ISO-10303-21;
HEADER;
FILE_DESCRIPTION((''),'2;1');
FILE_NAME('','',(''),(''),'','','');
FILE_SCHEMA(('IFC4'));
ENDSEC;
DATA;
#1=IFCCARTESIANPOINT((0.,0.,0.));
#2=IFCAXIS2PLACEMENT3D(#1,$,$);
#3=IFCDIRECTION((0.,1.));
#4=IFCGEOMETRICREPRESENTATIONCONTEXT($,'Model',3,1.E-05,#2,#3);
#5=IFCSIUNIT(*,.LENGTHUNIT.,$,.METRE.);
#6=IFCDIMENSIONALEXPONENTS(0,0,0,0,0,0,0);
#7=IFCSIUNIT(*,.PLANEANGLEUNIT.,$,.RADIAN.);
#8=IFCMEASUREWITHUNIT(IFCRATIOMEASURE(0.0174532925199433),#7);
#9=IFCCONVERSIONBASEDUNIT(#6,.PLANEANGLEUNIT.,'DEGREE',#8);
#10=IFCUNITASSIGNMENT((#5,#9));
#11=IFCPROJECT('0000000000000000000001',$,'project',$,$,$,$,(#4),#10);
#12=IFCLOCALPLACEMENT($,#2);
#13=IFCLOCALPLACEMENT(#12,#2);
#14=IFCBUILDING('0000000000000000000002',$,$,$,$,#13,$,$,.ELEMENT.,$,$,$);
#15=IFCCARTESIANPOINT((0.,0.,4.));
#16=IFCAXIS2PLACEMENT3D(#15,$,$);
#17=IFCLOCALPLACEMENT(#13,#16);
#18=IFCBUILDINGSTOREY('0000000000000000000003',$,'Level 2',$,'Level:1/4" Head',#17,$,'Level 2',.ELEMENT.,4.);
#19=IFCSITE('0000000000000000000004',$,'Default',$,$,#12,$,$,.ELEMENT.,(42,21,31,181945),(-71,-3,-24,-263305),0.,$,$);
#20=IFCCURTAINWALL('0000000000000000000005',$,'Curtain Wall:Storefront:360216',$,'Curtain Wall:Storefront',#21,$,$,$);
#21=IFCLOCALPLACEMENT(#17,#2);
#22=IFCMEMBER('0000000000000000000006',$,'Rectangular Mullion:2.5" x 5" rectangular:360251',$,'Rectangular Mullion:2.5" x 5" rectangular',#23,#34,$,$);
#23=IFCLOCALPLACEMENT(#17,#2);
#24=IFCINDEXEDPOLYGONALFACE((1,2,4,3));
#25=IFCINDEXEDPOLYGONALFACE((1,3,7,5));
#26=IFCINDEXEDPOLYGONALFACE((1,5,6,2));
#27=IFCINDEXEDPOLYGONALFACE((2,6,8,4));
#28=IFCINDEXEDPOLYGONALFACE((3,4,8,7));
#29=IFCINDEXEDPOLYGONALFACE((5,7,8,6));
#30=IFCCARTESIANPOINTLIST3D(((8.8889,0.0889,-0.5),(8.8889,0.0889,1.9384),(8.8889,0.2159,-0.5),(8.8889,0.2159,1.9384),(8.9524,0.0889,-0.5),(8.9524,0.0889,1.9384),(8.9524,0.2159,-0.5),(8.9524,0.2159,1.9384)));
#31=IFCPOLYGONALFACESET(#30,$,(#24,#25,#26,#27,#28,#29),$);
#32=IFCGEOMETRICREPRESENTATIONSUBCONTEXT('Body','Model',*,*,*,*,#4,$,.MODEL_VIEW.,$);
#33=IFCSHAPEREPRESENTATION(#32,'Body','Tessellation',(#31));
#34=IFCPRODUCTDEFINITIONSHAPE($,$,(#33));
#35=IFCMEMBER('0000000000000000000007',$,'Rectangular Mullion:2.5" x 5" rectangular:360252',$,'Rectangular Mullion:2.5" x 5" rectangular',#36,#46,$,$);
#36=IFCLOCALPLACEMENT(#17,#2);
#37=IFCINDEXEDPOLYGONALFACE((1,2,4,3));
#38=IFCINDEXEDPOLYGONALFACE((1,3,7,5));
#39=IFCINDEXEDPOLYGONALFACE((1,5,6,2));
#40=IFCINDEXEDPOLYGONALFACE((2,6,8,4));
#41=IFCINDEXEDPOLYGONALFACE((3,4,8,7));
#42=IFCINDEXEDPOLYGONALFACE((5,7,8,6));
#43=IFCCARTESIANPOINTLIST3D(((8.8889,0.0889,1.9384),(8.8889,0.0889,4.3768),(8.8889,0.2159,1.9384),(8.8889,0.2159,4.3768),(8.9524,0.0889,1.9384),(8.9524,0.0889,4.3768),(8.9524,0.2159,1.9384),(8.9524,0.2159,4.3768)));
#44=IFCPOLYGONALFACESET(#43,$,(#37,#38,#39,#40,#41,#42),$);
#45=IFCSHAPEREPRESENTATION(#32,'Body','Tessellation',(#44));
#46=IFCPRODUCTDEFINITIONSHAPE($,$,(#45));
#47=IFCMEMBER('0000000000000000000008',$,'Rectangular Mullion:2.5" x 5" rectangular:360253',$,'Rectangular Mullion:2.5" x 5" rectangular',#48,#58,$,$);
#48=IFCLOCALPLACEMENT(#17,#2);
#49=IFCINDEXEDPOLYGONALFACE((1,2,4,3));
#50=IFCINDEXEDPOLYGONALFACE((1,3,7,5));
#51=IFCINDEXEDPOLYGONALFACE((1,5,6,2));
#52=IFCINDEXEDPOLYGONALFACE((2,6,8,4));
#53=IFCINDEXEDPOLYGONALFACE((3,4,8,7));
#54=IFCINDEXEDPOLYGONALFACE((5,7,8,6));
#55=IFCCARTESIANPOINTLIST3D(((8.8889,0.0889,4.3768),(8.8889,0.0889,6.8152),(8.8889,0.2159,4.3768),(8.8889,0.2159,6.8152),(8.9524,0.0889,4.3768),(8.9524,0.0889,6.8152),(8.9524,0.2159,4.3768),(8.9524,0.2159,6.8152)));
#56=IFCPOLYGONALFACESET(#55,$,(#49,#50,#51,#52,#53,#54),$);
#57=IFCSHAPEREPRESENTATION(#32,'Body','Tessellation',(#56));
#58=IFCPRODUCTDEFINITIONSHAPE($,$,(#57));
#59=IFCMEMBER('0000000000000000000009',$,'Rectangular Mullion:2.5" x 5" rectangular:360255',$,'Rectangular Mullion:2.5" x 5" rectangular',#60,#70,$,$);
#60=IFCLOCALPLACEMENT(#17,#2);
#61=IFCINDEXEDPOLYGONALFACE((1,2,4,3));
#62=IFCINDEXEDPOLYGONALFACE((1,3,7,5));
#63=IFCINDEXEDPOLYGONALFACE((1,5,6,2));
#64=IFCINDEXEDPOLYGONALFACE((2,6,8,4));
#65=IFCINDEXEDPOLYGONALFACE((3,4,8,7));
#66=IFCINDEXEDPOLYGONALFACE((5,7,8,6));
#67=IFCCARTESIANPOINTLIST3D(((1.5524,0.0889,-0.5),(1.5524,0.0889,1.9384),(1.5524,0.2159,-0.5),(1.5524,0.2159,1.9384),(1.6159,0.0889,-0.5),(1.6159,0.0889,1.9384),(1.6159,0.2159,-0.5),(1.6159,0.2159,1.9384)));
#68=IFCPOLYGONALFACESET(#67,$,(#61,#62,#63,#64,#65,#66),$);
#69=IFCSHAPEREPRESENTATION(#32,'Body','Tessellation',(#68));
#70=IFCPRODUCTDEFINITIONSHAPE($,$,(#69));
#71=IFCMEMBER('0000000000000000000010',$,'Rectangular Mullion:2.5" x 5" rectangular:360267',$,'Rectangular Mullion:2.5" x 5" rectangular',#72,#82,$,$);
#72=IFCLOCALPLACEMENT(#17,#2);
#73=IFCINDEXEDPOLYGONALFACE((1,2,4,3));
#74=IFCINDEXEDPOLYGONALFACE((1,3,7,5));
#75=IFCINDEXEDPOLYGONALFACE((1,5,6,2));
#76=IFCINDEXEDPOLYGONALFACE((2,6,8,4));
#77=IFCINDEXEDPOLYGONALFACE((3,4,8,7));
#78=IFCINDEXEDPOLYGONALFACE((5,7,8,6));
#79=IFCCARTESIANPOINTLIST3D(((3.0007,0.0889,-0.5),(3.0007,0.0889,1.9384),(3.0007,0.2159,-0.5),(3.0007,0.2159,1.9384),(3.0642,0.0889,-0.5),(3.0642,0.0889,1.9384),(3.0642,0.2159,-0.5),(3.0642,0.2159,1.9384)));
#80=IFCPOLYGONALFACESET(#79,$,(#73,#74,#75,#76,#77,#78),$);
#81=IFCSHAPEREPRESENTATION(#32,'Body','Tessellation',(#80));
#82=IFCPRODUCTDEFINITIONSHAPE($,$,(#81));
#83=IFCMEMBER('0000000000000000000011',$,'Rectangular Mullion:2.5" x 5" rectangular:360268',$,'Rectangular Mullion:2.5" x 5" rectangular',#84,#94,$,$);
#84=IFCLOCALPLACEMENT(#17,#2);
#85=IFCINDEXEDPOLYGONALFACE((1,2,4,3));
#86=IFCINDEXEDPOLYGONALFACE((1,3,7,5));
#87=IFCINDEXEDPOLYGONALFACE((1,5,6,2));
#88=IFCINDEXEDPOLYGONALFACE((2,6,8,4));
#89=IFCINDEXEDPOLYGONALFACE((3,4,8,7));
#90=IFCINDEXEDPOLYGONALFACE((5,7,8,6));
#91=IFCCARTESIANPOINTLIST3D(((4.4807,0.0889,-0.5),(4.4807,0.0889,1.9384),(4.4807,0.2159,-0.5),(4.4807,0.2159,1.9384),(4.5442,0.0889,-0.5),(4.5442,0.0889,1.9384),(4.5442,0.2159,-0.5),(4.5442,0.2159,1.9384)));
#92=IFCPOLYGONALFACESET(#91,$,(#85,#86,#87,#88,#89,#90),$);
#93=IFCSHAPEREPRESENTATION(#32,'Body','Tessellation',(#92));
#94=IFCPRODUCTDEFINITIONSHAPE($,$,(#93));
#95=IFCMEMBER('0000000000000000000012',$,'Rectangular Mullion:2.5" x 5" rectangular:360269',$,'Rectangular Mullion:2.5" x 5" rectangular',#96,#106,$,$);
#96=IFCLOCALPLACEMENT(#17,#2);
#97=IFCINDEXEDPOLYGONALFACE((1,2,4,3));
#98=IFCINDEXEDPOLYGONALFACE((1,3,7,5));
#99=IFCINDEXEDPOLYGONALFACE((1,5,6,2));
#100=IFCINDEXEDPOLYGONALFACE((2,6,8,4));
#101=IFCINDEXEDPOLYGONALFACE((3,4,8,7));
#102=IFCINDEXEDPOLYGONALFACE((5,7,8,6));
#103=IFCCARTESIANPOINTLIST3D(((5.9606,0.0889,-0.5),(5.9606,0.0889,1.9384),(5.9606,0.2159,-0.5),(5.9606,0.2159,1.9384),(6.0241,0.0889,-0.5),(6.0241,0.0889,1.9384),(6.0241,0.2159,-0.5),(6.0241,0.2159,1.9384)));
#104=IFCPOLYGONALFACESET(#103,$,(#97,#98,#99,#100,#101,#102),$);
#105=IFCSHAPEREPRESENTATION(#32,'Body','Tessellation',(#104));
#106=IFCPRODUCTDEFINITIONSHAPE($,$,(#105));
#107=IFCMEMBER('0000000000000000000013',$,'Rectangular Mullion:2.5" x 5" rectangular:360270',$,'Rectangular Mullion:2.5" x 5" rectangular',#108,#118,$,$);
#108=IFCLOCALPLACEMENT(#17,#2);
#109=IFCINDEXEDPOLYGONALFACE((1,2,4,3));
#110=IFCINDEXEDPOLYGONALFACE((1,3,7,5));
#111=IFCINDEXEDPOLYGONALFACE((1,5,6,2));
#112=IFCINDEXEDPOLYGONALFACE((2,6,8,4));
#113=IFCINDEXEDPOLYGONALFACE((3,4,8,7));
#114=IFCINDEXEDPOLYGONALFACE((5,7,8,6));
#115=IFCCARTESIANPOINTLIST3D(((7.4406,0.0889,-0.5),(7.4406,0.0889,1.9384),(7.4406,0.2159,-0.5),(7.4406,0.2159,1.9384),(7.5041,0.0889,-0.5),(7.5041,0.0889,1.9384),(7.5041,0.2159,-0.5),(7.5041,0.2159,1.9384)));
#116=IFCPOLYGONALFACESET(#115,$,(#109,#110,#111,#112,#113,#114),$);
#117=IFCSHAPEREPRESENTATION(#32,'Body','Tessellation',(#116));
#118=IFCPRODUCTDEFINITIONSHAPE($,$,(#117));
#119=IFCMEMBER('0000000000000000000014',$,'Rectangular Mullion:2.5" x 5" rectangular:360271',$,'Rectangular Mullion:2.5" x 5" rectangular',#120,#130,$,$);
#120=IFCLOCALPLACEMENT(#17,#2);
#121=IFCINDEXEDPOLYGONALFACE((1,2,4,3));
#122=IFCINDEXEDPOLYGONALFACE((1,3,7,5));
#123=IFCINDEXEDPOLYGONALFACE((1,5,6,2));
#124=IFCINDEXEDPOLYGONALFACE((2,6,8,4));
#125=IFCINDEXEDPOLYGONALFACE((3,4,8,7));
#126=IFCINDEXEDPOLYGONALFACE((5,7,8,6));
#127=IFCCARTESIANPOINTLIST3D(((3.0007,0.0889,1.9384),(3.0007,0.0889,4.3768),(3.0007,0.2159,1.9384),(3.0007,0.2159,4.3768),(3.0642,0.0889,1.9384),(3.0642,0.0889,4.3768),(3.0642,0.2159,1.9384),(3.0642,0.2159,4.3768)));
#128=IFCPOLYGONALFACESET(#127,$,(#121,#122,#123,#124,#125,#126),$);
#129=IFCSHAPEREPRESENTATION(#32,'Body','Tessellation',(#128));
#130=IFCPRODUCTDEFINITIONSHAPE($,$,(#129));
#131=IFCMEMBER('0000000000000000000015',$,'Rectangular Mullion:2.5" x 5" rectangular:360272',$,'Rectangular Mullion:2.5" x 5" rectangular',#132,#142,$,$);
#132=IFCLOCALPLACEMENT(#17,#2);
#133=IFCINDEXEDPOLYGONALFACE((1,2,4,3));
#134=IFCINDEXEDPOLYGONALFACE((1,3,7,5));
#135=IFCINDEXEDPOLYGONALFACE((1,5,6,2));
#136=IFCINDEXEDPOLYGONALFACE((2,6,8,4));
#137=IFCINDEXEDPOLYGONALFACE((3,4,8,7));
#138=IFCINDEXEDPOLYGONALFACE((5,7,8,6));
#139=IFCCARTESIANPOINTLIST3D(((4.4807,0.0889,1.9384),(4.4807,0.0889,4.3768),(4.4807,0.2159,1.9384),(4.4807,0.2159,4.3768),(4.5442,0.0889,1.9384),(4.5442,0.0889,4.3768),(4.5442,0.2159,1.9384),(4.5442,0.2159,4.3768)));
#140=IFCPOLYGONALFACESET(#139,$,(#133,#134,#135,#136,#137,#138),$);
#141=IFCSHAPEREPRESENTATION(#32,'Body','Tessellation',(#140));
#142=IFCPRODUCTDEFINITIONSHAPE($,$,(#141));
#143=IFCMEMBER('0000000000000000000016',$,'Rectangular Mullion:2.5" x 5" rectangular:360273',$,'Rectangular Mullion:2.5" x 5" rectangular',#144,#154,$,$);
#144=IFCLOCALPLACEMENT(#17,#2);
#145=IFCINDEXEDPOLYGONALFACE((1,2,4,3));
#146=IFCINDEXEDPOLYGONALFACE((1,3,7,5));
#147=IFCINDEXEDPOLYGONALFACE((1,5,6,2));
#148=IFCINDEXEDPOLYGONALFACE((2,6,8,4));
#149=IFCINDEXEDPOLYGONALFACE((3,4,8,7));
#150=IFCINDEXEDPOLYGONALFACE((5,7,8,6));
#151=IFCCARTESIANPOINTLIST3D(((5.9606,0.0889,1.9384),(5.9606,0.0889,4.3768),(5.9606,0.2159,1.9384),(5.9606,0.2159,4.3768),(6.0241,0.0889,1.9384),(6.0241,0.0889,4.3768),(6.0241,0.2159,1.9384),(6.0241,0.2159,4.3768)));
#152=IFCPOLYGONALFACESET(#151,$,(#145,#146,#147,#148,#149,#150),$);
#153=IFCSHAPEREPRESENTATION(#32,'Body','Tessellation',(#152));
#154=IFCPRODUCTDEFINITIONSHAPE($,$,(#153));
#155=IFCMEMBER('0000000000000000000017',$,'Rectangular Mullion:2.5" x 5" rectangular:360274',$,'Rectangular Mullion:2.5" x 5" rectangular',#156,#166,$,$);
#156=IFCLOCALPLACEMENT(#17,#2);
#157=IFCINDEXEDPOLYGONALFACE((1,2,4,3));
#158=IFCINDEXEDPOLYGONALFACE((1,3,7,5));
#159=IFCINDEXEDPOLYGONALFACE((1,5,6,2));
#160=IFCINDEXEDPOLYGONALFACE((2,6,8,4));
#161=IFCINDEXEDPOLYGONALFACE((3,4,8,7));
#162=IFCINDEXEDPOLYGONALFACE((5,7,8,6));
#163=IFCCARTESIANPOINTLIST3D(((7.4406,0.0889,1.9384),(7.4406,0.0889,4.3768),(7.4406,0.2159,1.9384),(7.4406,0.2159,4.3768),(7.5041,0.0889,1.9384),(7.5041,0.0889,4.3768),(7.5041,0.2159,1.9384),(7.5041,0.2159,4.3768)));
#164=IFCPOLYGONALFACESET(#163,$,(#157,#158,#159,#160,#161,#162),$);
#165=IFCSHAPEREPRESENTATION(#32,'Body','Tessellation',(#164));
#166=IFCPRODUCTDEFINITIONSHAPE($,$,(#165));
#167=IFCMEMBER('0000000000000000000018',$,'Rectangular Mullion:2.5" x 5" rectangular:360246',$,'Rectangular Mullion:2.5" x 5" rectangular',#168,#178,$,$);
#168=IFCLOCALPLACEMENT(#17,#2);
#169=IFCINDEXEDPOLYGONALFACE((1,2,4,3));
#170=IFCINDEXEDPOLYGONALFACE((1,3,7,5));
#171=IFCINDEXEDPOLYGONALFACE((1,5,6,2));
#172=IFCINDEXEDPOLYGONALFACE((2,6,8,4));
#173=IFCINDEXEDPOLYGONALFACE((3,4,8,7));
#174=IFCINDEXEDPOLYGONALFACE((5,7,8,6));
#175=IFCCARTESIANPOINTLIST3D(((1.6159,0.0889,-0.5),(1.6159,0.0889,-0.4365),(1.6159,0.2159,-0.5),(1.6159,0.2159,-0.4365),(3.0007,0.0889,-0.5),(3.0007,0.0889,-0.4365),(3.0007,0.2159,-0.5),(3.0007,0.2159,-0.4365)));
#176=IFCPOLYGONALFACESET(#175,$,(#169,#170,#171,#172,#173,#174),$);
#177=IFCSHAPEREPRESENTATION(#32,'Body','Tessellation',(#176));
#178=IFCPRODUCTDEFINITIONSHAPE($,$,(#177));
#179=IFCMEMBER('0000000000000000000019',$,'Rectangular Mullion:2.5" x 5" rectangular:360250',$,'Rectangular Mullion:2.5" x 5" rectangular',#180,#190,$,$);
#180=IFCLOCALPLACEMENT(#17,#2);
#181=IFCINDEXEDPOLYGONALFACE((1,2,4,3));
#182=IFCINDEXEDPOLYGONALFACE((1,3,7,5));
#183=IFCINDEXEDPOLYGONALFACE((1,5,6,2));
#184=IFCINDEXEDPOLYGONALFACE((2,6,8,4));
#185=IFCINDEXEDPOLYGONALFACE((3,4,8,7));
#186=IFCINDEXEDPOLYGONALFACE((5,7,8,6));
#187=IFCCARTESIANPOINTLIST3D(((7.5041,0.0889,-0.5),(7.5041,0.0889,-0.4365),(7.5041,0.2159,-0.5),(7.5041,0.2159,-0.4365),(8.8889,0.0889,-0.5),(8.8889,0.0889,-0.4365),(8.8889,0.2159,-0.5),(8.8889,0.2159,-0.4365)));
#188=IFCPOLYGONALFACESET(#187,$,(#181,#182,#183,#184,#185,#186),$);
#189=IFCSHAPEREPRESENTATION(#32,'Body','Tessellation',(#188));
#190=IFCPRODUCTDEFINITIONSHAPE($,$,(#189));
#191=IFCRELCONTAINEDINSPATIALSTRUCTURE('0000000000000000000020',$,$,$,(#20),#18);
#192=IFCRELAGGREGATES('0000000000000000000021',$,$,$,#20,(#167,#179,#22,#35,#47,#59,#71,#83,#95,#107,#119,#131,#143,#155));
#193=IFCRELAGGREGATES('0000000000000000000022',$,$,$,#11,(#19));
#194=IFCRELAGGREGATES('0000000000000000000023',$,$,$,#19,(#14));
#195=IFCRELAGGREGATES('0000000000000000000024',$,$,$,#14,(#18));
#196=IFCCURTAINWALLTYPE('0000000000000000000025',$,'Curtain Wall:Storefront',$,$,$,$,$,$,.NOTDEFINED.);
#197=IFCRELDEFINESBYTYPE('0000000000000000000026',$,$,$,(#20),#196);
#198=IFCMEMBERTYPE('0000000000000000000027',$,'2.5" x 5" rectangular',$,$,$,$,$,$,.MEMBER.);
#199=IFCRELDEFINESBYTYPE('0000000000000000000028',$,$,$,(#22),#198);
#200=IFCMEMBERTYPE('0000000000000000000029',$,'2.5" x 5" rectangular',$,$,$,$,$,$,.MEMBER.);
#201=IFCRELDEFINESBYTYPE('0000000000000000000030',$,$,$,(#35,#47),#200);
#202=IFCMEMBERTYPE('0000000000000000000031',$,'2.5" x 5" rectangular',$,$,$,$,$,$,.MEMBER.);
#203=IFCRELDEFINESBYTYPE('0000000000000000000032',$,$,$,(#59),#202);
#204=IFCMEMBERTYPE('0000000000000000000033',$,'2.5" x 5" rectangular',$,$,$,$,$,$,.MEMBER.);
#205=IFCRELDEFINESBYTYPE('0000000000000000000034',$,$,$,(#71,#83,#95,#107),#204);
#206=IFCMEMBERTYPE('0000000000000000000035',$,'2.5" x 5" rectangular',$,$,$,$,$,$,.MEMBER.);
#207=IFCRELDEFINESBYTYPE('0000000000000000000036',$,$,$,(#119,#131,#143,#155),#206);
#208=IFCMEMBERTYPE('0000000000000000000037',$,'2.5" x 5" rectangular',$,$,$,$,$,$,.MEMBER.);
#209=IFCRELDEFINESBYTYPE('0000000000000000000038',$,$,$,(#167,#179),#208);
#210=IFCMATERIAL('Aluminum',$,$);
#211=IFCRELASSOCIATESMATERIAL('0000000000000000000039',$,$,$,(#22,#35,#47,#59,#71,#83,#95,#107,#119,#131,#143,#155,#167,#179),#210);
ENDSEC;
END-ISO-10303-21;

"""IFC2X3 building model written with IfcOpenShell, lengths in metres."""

from ifc_helpers import new_model, entity, si_unit, converted_unit, direction, frame, origin, origin_2d_with_axis, place, context, subcontext, project, spatial, rectangle, extrude, source, transform, mapped, material, type_object, type_shapes, element, aggregate, save


model = new_model("IFC2X3")

# Units and contexts
model_context = context("Model", 3, precision=1e-05, world=origin(), true_north=direction((0.0, 1.0)))
body_context = subcontext(model_context, "Body", "Model", "MODEL_VIEW")
ifc_project = project(units=[si_unit("LENGTHUNIT", "METRE"), converted_unit("PLANEANGLEUNIT", "DEGREE", entity("IfcRatioMeasure", 0.0174532925199433), si_unit("PLANEANGLEUNIT", "RADIAN"), dimensions=[0, 0, 0, 0, 0, 0, 0])], contexts=[model_context])

# Site, building, storey
site_placement = place(None, origin())
site = spatial("IfcSite", under=ifc_project, at=site_placement, Name="Default", CompositionType="ELEMENT", RefLatitude=(42, 21, 31, 181945), RefLongitude=(-71, -3, -24, -263305), RefElevation=0.0)
building_placement = place(site_placement, origin())
building = spatial("IfcBuilding", under=site, at=building_placement, CompositionType="ELEMENT")
storey_placement = place(building_placement, frame((0.0, 0.0, 4.0)))
storey = spatial("IfcBuildingStorey", under=building, at=storey_placement, Name="Level 2", ObjectType="Level:1/4\" Head", LongName="Level 2", CompositionType="ELEMENT", Elevation=4.0)

# Curtain wall, members
curtain_wall_type = type_object("IfcCurtainWallType", Name="Curtain Wall:Storefront", PredefinedType="NOTDEFINED")
curtain_wall_placement = place(storey_placement, frame((0.0, 0.0, -4.0)))
curtain_wall = element("IfcCurtainWall", 1, at=curtain_wall_placement, inside=storey, type_object=curtain_wall_type, Name="Curtain Wall:Storefront:360216", ObjectType="Curtain Wall:Storefront")
ifc_material_1 = material(Name="Aluminum")
member_type_1 = type_object("IfcMemberType", Name="2.5\" x 5\" rectangular", PredefinedType="MEMBER")
shared_shape_1 = source(origin(), body_context, "Body", "SweptSolid", [
    extrude(rectangle(XDim=0.127, YDim=0.0635, at=origin_2d_with_axis()), frame((-0.0318, 0.0, -2.4384), z_axis=(0.0, 0.0, 1.0), x_axis=(0.0, -1.0, 0.0)), (0.0, 0.0, 1.0), 2.4384),
])
type_shapes(member_type_1, [shared_shape_1])
member_1_placement = place(storey_placement, frame((8.9524, 0.1524, -0.5), z_axis=(0.0, 0.0, -1.0), x_axis=(1.0, 0.0, 0.0)))
member_1 = element("IfcMember", 2, at=member_1_placement, type_object=member_type_1, material=ifc_material_1, Name="Rectangular Mullion:2.5\" x 5\" rectangular:360251", ObjectType="Rectangular Mullion:2.5\" x 5\" rectangular", context=body_context, shape_type="MappedRepresentation", body=[
    mapped(shared_shape_1, transform((0.0, 0.0, 0.0), scale=1.0)),
])
member_type_2 = type_object("IfcMemberType", Name="2.5\" x 5\" rectangular", PredefinedType="MEMBER")
shared_shape_2 = source(origin(), body_context, "Body", "SweptSolid", [
    extrude(rectangle(XDim=0.127, YDim=0.0635, at=origin_2d_with_axis()), frame((-0.0318, 0.0, -2.4384), z_axis=(0.0, 0.0, 1.0), x_axis=(0.0, -1.0, 0.0)), (0.0, 0.0, 1.0), 2.4384),
])
type_shapes(member_type_2, [shared_shape_2])
member_2_placement = place(storey_placement, frame((8.9524, 0.1524, 1.9384), z_axis=(0.0, 0.0, -1.0), x_axis=(1.0, 0.0, 0.0)))
member_2 = element("IfcMember", 3, at=member_2_placement, type_object=member_type_2, material=ifc_material_1, Name="Rectangular Mullion:2.5\" x 5\" rectangular:360252", ObjectType="Rectangular Mullion:2.5\" x 5\" rectangular", context=body_context, shape_type="MappedRepresentation", body=[
    mapped(shared_shape_2, transform((0.0, 0.0, 0.0), scale=1.0)),
])
member_3_placement = place(storey_placement, frame((8.9524, 0.1524, 4.3768), z_axis=(0.0, 0.0, -1.0), x_axis=(1.0, 0.0, 0.0)))
member_3 = element("IfcMember", 4, at=member_3_placement, type_object=member_type_2, material=ifc_material_1, Name="Rectangular Mullion:2.5\" x 5\" rectangular:360253", ObjectType="Rectangular Mullion:2.5\" x 5\" rectangular", context=body_context, shape_type="MappedRepresentation", body=[
    mapped(shared_shape_2, transform((0.0, 0.0, 0.0), scale=1.0)),
])
member_type_3 = type_object("IfcMemberType", Name="2.5\" x 5\" rectangular", PredefinedType="MEMBER")
shared_shape_3 = source(origin(), body_context, "Body", "SweptSolid", [
    extrude(rectangle(XDim=0.127, YDim=0.0635, at=origin_2d_with_axis()), frame((-0.0318, 0.0, -2.4384), z_axis=(0.0, 0.0, 1.0), x_axis=(0.0, -1.0, 0.0)), (0.0, 0.0, 1.0), 2.4384),
])
type_shapes(member_type_3, [shared_shape_3])
member_4_placement = place(storey_placement, frame((1.5524, 0.1524, 1.9384), z_axis=(0.0, 0.0, 1.0), x_axis=(-1.0, 0.0, 0.0)))
member_4 = element("IfcMember", 5, at=member_4_placement, type_object=member_type_3, material=ifc_material_1, Name="Rectangular Mullion:2.5\" x 5\" rectangular:360255", ObjectType="Rectangular Mullion:2.5\" x 5\" rectangular", context=body_context, shape_type="MappedRepresentation", body=[
    mapped(shared_shape_3, transform((0.0, 0.0, 0.0), scale=1.0)),
])
member_type_4 = type_object("IfcMemberType", Name="2.5\" x 5\" rectangular", PredefinedType="MEMBER")
shared_shape_4 = source(origin(), body_context, "Body", "SweptSolid", [
    extrude(rectangle(XDim=0.127, YDim=0.0635, at=origin_2d_with_axis()), frame((0.0, 0.0, -2.4384), z_axis=(0.0, 0.0, 1.0), x_axis=(0.0, -1.0, 0.0)), (0.0, 0.0, 1.0), 2.4384),
])
type_shapes(member_type_4, [shared_shape_4])
member_5_placement = place(storey_placement, frame((3.0324, 0.1524, -0.5), z_axis=(0.0, 0.0, -1.0), x_axis=(1.0, 0.0, 0.0)))
member_5 = element("IfcMember", 6, at=member_5_placement, type_object=member_type_4, material=ifc_material_1, Name="Rectangular Mullion:2.5\" x 5\" rectangular:360267", ObjectType="Rectangular Mullion:2.5\" x 5\" rectangular", context=body_context, shape_type="MappedRepresentation", body=[
    mapped(shared_shape_4, transform((0.0, 0.0, 0.0), scale=1.0)),
])
member_6_placement = place(storey_placement, frame((4.5124, 0.1524, -0.5), z_axis=(0.0, 0.0, -1.0), x_axis=(1.0, 0.0, 0.0)))
member_6 = element("IfcMember", 7, at=member_6_placement, type_object=member_type_4, material=ifc_material_1, Name="Rectangular Mullion:2.5\" x 5\" rectangular:360268", ObjectType="Rectangular Mullion:2.5\" x 5\" rectangular", context=body_context, shape_type="MappedRepresentation", body=[
    mapped(shared_shape_4, transform((0.0, 0.0, 0.0), scale=1.0)),
])
member_7_placement = place(storey_placement, frame((5.9924, 0.1524, -0.5), z_axis=(0.0, 0.0, -1.0), x_axis=(1.0, 0.0, 0.0)))
member_7 = element("IfcMember", 8, at=member_7_placement, type_object=member_type_4, material=ifc_material_1, Name="Rectangular Mullion:2.5\" x 5\" rectangular:360269", ObjectType="Rectangular Mullion:2.5\" x 5\" rectangular", context=body_context, shape_type="MappedRepresentation", body=[
    mapped(shared_shape_4, transform((0.0, 0.0, 0.0), scale=1.0)),
])
member_8_placement = place(storey_placement, frame((7.4724, 0.1524, -0.5), z_axis=(0.0, 0.0, -1.0), x_axis=(1.0, 0.0, 0.0)))
member_8 = element("IfcMember", 9, at=member_8_placement, type_object=member_type_4, material=ifc_material_1, Name="Rectangular Mullion:2.5\" x 5\" rectangular:360270", ObjectType="Rectangular Mullion:2.5\" x 5\" rectangular", context=body_context, shape_type="MappedRepresentation", body=[
    mapped(shared_shape_4, transform((0.0, 0.0, 0.0), scale=1.0)),
])
member_type_5 = type_object("IfcMemberType", Name="2.5\" x 5\" rectangular", PredefinedType="MEMBER")
shared_shape_5 = source(origin(), body_context, "Body", "SweptSolid", [
    extrude(rectangle(XDim=0.127, YDim=0.0635, at=origin_2d_with_axis()), frame((0.0, 0.0, -2.4384), z_axis=(0.0, 0.0, 1.0), x_axis=(0.0, -1.0, 0.0)), (0.0, 0.0, 1.0), 2.4384),
])
type_shapes(member_type_5, [shared_shape_5])
member_9_placement = place(storey_placement, frame((3.0324, 0.1524, 1.9384), z_axis=(0.0, 0.0, -1.0), x_axis=(1.0, 0.0, 0.0)))
member_9 = element("IfcMember", 10, at=member_9_placement, type_object=member_type_5, material=ifc_material_1, Name="Rectangular Mullion:2.5\" x 5\" rectangular:360271", ObjectType="Rectangular Mullion:2.5\" x 5\" rectangular", context=body_context, shape_type="MappedRepresentation", body=[
    mapped(shared_shape_5, transform((0.0, 0.0, 0.0), scale=1.0)),
])
member_10_placement = place(storey_placement, frame((4.5124, 0.1524, 1.9384), z_axis=(0.0, 0.0, -1.0), x_axis=(1.0, 0.0, 0.0)))
member_10 = element("IfcMember", 11, at=member_10_placement, type_object=member_type_5, material=ifc_material_1, Name="Rectangular Mullion:2.5\" x 5\" rectangular:360272", ObjectType="Rectangular Mullion:2.5\" x 5\" rectangular", context=body_context, shape_type="MappedRepresentation", body=[
    mapped(shared_shape_5, transform((0.0, 0.0, 0.0), scale=1.0)),
])
member_11_placement = place(storey_placement, frame((5.9924, 0.1524, 1.9384), z_axis=(0.0, 0.0, -1.0), x_axis=(1.0, 0.0, 0.0)))
member_11 = element("IfcMember", 12, at=member_11_placement, type_object=member_type_5, material=ifc_material_1, Name="Rectangular Mullion:2.5\" x 5\" rectangular:360273", ObjectType="Rectangular Mullion:2.5\" x 5\" rectangular", context=body_context, shape_type="MappedRepresentation", body=[
    mapped(shared_shape_5, transform((0.0, 0.0, 0.0), scale=1.0)),
])
member_12_placement = place(storey_placement, frame((7.4724, 0.1524, 1.9384), z_axis=(0.0, 0.0, -1.0), x_axis=(1.0, 0.0, 0.0)))
member_12 = element("IfcMember", 13, at=member_12_placement, type_object=member_type_5, material=ifc_material_1, Name="Rectangular Mullion:2.5\" x 5\" rectangular:360274", ObjectType="Rectangular Mullion:2.5\" x 5\" rectangular", context=body_context, shape_type="MappedRepresentation", body=[
    mapped(shared_shape_5, transform((0.0, 0.0, 0.0), scale=1.0)),
])
member_type_6 = type_object("IfcMemberType", Name="2.5\" x 5\" rectangular", PredefinedType="MEMBER")
shared_shape_6 = source(origin(), body_context, "Body", "SweptSolid", [
    extrude(rectangle(XDim=0.127, YDim=0.0635, at=origin_2d_with_axis()), frame((-0.0318, 0.0, -1.3848), z_axis=(0.0, 0.0, 1.0), x_axis=(0.0, -1.0, 0.0)), (0.0, 0.0, 1.0), 1.3848),
])
type_shapes(member_type_6, [shared_shape_6])
member_13_placement = place(storey_placement, frame((1.6159, 0.1524, -0.5), z_axis=(-1.0, 0.0, 0.0), x_axis=(0.0, 0.0, -1.0)))
member_13 = element("IfcMember", 14, at=member_13_placement, type_object=member_type_6, material=ifc_material_1, Name="Rectangular Mullion:2.5\" x 5\" rectangular:360246", ObjectType="Rectangular Mullion:2.5\" x 5\" rectangular", context=body_context, shape_type="MappedRepresentation", body=[
    mapped(shared_shape_6, transform((0.0, 0.0, 0.0), scale=1.0)),
])
member_14_placement = place(storey_placement, frame((7.5041, 0.1524, -0.5), z_axis=(-1.0, 0.0, 0.0), x_axis=(0.0, 0.0, -1.0)))
member_14 = element("IfcMember", 15, at=member_14_placement, type_object=member_type_6, material=ifc_material_1, Name="Rectangular Mullion:2.5\" x 5\" rectangular:360250", ObjectType="Rectangular Mullion:2.5\" x 5\" rectangular", context=body_context, shape_type="MappedRepresentation", body=[
    mapped(shared_shape_6, transform((0.0, 0.0, 0.0), scale=1.0)),
])

aggregate(curtain_wall, [member_13, member_14, member_1, member_2, member_3, member_4, member_5, member_6, member_7, member_8, member_9, member_10, member_11, member_12])

save(model, "model.ifc")
